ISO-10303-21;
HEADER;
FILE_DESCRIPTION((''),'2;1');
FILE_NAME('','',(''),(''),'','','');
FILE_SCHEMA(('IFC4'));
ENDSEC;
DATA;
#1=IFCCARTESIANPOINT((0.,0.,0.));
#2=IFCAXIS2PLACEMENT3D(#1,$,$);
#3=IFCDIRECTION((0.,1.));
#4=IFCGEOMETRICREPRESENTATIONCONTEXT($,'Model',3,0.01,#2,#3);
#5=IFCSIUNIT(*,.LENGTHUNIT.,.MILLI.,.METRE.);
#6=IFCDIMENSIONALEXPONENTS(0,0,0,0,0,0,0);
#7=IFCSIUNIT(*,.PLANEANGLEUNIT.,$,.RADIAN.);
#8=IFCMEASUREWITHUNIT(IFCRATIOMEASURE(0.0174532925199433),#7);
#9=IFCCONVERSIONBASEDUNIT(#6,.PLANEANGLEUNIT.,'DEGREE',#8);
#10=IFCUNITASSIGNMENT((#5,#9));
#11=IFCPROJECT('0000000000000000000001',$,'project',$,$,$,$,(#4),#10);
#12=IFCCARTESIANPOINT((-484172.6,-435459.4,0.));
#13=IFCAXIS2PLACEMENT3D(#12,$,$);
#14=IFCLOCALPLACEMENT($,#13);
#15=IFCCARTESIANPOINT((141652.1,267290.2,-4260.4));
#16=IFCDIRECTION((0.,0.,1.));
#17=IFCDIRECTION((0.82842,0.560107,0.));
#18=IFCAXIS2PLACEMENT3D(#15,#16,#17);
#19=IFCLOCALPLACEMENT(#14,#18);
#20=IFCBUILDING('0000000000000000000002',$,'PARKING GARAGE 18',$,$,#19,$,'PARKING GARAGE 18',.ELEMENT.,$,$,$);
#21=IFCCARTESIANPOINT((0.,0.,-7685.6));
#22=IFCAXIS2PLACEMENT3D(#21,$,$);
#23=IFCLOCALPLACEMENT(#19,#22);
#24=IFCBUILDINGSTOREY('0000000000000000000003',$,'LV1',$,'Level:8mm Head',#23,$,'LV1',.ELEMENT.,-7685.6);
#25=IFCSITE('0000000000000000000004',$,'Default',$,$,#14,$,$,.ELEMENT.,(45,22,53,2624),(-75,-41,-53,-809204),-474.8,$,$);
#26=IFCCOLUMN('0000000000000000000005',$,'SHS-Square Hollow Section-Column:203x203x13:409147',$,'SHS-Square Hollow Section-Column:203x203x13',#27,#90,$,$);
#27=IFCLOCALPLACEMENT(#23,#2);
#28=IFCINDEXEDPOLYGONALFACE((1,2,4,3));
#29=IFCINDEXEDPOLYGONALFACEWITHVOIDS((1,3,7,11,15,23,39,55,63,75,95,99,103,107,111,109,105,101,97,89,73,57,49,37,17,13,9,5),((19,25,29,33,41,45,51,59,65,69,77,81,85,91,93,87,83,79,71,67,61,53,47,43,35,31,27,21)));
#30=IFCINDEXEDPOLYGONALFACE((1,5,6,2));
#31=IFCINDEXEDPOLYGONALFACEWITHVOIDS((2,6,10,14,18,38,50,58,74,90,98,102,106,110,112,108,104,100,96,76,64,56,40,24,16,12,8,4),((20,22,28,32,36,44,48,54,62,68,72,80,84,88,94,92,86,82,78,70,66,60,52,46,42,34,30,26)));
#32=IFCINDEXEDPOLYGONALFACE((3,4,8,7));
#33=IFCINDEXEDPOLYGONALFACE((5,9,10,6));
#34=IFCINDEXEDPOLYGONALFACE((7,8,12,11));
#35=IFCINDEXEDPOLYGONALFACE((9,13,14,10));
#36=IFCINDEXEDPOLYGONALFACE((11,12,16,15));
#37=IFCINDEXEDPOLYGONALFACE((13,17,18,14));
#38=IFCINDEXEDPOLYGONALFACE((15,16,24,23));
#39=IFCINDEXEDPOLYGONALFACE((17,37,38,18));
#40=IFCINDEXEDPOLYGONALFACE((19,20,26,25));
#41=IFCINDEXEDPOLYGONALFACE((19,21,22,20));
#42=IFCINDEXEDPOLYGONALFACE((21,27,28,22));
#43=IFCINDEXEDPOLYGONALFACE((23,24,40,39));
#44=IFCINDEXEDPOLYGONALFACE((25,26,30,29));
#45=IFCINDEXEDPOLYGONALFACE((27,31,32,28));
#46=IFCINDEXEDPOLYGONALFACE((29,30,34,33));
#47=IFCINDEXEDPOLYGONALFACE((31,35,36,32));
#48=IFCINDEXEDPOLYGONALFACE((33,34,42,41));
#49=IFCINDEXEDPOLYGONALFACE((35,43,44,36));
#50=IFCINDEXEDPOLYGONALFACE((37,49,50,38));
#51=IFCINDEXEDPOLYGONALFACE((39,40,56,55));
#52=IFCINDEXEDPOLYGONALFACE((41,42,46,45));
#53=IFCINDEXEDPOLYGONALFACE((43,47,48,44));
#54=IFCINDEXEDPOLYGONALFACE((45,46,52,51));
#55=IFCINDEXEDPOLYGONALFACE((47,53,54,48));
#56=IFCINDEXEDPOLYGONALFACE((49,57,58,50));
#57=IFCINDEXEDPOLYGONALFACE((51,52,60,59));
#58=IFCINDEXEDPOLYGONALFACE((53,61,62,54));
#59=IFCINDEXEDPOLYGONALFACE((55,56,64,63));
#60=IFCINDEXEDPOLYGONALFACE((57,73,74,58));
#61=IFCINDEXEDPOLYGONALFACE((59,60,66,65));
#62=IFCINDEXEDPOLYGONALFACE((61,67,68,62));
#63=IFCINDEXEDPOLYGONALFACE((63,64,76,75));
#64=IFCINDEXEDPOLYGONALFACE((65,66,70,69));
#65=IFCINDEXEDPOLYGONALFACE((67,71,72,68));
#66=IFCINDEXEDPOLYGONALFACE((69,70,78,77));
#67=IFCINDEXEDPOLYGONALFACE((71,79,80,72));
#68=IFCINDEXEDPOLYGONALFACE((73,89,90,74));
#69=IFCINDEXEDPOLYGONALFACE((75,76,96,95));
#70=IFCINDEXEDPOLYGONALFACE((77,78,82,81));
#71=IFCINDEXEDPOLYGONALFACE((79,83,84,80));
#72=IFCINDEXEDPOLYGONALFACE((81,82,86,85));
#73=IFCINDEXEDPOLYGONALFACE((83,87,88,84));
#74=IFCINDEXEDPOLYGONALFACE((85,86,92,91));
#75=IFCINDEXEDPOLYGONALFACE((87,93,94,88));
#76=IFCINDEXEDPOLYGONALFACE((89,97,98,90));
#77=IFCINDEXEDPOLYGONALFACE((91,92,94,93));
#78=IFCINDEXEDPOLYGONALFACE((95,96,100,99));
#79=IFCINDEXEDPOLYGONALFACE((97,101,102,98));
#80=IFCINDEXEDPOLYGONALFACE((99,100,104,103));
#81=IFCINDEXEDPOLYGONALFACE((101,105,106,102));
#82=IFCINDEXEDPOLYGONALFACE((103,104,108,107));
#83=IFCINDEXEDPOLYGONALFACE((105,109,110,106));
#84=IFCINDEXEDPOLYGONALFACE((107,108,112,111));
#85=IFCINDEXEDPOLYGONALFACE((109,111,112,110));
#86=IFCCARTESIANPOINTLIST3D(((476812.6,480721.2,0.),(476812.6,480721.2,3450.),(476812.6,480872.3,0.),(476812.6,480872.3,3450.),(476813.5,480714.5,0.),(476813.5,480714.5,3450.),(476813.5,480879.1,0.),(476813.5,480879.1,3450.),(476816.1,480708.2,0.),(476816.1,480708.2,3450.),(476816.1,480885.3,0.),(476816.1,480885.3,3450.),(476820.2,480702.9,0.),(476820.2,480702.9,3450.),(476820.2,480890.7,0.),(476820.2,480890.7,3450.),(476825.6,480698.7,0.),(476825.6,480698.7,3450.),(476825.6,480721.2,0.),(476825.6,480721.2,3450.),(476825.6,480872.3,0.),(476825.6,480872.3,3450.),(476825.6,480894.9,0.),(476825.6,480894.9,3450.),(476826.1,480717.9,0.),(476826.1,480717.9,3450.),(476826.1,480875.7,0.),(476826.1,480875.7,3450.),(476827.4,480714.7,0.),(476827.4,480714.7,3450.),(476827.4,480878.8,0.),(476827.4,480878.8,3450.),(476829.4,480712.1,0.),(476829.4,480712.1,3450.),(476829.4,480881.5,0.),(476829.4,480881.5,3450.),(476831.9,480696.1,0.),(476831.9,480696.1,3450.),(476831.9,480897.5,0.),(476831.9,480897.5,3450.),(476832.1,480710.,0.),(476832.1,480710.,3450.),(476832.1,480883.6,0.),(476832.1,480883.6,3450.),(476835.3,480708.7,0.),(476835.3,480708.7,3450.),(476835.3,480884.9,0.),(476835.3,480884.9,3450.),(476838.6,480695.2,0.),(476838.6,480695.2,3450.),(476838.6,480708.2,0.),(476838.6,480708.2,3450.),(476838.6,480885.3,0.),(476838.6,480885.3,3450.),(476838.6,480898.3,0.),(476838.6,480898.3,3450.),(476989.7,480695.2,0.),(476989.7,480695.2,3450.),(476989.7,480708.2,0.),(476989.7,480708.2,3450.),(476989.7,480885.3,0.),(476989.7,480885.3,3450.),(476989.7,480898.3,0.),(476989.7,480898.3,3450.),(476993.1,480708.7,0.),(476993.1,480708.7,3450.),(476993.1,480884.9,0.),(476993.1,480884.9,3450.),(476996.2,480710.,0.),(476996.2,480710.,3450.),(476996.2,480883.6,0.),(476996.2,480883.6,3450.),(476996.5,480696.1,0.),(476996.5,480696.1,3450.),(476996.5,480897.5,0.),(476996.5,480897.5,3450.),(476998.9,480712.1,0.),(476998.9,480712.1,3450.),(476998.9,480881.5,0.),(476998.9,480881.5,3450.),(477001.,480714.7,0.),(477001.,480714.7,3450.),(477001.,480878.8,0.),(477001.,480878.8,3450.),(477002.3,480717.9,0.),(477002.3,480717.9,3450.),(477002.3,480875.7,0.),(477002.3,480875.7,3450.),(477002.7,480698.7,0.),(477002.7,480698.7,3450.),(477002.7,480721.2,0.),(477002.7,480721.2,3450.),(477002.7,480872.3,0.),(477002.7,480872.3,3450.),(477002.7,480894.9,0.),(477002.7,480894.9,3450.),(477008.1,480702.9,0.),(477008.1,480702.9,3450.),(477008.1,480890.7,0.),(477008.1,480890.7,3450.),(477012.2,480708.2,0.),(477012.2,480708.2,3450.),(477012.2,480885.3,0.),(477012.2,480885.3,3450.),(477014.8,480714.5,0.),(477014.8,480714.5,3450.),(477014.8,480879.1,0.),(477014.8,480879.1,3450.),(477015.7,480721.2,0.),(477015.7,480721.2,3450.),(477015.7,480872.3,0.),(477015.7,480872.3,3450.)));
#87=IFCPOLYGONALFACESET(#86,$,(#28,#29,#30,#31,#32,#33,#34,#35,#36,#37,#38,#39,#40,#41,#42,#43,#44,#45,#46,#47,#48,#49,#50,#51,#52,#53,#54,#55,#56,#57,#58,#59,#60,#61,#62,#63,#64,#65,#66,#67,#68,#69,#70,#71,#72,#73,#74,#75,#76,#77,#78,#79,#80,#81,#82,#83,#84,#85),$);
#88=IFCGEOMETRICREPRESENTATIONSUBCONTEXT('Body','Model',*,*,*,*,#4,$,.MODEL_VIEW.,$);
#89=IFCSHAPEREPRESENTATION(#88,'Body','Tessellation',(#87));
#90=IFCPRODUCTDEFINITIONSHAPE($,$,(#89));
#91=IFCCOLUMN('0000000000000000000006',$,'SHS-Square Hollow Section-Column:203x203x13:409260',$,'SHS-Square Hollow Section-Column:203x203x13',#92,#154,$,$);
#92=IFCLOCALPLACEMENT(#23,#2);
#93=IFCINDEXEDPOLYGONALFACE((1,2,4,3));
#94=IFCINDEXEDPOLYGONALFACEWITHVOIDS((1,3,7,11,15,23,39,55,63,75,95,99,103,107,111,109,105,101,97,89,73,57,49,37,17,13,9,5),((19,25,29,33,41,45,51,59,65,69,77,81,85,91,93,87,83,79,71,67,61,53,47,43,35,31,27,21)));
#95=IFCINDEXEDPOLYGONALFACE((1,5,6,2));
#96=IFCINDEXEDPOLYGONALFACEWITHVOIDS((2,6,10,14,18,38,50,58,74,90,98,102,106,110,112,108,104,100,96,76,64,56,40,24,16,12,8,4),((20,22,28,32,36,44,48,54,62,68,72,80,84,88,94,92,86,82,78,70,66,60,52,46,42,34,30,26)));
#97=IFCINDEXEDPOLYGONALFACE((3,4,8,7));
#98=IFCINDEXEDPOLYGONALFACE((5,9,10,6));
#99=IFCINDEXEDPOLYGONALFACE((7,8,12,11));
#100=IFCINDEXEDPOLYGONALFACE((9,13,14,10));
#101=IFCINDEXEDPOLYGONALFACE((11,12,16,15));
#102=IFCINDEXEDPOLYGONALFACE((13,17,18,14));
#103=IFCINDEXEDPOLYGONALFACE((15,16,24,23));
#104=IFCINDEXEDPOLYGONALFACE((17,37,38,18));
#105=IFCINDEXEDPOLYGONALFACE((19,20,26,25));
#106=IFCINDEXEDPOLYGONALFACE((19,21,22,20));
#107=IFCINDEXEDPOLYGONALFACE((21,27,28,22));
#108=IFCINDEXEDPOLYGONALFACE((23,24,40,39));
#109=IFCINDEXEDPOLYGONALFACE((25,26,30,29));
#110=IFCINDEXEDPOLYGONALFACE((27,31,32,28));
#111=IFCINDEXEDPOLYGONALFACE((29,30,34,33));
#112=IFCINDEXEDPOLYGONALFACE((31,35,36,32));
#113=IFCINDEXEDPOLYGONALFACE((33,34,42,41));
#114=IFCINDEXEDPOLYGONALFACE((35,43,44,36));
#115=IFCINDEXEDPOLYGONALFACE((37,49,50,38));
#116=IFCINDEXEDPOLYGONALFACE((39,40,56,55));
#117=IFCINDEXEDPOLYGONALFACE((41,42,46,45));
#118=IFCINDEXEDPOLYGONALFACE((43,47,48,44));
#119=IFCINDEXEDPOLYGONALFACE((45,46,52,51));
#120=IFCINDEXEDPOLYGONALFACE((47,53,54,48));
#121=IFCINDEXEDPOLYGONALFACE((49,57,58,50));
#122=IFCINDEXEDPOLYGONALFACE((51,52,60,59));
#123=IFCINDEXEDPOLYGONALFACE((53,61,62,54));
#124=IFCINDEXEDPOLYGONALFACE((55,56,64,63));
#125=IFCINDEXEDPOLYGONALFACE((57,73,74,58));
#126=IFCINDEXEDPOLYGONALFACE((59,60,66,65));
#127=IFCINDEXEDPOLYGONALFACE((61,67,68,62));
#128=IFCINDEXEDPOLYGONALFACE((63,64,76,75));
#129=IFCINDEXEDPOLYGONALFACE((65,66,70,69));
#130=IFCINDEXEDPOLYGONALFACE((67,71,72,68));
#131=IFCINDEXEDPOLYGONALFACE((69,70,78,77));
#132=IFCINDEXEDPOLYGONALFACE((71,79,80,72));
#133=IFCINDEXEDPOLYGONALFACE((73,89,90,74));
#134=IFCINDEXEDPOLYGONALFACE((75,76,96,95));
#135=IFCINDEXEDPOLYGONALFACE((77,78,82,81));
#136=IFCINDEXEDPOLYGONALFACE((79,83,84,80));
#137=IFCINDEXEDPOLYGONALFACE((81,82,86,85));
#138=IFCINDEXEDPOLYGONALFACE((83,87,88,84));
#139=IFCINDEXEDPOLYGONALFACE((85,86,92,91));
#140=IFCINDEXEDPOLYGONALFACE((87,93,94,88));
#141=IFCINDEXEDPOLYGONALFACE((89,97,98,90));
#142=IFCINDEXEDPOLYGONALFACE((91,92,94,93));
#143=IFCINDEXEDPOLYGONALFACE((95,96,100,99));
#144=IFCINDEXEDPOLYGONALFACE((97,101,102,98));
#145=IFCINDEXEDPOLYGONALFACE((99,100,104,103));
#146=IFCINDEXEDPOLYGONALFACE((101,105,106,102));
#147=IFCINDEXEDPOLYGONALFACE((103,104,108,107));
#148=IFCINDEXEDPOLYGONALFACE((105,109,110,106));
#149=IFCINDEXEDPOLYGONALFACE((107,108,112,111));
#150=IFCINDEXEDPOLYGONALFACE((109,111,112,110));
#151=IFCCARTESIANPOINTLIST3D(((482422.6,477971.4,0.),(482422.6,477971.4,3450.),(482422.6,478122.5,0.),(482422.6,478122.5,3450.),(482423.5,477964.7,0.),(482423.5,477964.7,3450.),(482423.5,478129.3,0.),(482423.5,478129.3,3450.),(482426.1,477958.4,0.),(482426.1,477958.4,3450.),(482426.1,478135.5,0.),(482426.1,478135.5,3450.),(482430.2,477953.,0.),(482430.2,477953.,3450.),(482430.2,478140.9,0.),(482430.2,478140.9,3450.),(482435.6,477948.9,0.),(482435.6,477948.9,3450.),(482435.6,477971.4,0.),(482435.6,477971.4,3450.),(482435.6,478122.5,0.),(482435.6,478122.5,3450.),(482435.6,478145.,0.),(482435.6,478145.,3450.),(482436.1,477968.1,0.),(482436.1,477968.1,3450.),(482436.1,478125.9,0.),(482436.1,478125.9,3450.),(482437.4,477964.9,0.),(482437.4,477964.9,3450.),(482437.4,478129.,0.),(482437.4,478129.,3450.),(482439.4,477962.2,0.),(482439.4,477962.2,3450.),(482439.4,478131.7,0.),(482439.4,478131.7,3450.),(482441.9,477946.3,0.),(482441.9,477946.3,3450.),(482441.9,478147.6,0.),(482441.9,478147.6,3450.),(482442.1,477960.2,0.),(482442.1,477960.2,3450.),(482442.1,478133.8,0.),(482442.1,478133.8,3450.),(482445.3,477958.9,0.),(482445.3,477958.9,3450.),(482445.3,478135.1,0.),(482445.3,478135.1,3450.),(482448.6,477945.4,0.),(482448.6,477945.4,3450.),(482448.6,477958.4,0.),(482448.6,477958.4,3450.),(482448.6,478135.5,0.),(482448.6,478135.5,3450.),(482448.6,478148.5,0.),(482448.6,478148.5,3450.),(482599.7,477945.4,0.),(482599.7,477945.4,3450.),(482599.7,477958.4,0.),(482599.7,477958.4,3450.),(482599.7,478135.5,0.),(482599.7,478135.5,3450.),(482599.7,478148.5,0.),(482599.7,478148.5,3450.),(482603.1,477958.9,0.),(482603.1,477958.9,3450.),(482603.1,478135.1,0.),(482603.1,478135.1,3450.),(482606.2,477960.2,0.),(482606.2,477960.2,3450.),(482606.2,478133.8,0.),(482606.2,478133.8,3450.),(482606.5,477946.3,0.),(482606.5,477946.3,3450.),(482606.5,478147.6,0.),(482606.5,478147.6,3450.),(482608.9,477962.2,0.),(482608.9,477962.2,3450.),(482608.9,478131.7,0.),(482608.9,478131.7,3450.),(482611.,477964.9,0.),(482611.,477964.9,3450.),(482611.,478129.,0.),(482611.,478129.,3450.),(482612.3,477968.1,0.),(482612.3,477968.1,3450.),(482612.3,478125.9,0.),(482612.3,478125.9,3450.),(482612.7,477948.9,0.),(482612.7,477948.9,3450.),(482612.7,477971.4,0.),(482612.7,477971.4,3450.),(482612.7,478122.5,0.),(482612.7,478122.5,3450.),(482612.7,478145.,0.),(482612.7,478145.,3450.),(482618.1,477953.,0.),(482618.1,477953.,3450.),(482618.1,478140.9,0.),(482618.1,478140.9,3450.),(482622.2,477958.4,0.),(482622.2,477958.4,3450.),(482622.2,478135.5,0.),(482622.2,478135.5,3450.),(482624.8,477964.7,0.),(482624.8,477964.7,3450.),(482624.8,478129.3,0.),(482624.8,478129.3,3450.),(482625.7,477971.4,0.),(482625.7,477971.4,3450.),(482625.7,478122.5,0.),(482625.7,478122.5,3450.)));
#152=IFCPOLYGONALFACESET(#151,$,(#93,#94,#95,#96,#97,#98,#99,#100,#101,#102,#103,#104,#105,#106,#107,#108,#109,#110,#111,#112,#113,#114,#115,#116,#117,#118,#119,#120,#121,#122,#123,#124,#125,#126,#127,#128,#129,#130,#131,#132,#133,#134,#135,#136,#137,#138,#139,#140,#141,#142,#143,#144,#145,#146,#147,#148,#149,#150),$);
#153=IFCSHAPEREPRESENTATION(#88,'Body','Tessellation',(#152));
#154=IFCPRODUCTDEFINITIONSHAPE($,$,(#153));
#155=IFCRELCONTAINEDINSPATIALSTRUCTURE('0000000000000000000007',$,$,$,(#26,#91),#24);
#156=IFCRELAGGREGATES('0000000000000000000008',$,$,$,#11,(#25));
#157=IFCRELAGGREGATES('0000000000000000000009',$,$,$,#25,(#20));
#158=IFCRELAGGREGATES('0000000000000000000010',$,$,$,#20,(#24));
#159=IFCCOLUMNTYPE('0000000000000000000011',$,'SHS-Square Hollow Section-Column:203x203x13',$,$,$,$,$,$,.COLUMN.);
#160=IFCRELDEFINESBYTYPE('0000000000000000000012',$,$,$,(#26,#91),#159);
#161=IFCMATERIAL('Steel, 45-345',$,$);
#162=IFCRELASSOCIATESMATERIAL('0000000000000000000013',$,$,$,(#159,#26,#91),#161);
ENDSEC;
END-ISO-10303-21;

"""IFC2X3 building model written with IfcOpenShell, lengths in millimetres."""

from ifc_helpers import new_model, entity, si_unit, converted_unit, direction, frame, frame_2d, origin, place, context, subcontext, project, spatial, polyline, circle_curve, parameter, trimmed, segment, composite_curve, outline, extrude, source, transform, mapped, material, type_object, type_shapes, element, save


model = new_model("IFC2X3")

# Units and contexts
model_context = context("Model", 3, precision=0.01, world=origin(), true_north=direction((0.0, 1.0)))
body_context = subcontext(model_context, "Body", "Model", "MODEL_VIEW")
ifc_project = project(units=[si_unit("LENGTHUNIT", "METRE", prefix="MILLI"), converted_unit("PLANEANGLEUNIT", "DEGREE", entity("IfcRatioMeasure", 0.0174532925199433), si_unit("PLANEANGLEUNIT", "RADIAN"), dimensions=[0, 0, 0, 0, 0, 0, 0])], contexts=[model_context])

# Site, building, storey
site_placement = place(None, frame((-484172.6, -435459.4, 0.0)))
site = spatial("IfcSite", under=ifc_project, at=site_placement, Name="Default", CompositionType="ELEMENT", RefLatitude=(45, 22, 53, 2624), RefLongitude=(-75, -41, -53, -809204), RefElevation=-474.8)
building_placement = place(site_placement, frame((141652.1, 267290.2, -4260.4), z_axis=(0.0, 0.0, 1.0), x_axis=(0.82842, 0.560107, 0.0)))
building = spatial("IfcBuilding", under=site, at=building_placement, Name="PARKING GARAGE 18", LongName="PARKING GARAGE 18", CompositionType="ELEMENT")
storey_placement = place(building_placement, frame((0.0, 0.0, -7685.6)))
storey = spatial("IfcBuildingStorey", under=building, at=storey_placement, Name="LV1", ObjectType="Level:8mm Head", LongName="LV1", CompositionType="ELEMENT", Elevation=-7685.6)

# Columns
ifc_material_1 = material(Name="Steel, 45-345")
column_type_1 = type_object("IfcColumnType", Name="SHS-Square Hollow Section-Column:203x203x13", PredefinedType="COLUMN", material=ifc_material_1)
shared_shape_1 = source(origin(), body_context, "Body", "SweptSolid", [
    extrude(outline(composite_curve([segment(polyline([(-75.6, -101.5), (75.6, -101.5)]), True, "CONTINUOUS"), segment(trimmed(circle_curve(frame_2d((75.6, -75.6), x_axis=(-1.0, 0.0)), 26.0), [parameter(90.0)], [parameter(180.0)], True, "PARAMETER"), True, "CONTINUOUS"), segment(polyline([(101.5, -75.6), (101.5, 75.6)]), True, "CONTINUOUS"), segment(trimmed(circle_curve(frame_2d((75.5, 75.6), x_axis=(-1.0, 0.0)), 26.0), [parameter(180.0)], [parameter(270.0)], True, "PARAMETER"), True, "CONTINUOUS"), segment(polyline([(75.5, 101.6), (-75.5, 101.6)]), True, "CONTINUOUS"), segment(trimmed(circle_curve(frame_2d((-75.5, 75.5), x_axis=(-1.0, 0.0)), 26.0), [parameter(270.0)], [parameter(360.0)], True, "PARAMETER"), True, "CONTINUOUS"), segment(polyline([(-101.5, 75.5), (-101.5, -75.6)]), True, "CONTINUOUS"), segment(trimmed(circle_curve(frame_2d((-75.6, -75.6), x_axis=(-1.0, 0.0)), 26.0), [parameter(360.0)], [parameter(90.0)], True, "PARAMETER"), True, "CONTINUOUS")], self_intersect=False), holes=[composite_curve([segment(trimmed(circle_curve(frame_2d((-75.6, -75.6), x_axis=(-1.0, 0.0)), 13.0), [parameter(0.0)], [parameter(90.0)], True, "PARAMETER"), False, "CONTINUOUS"), segment(polyline([(-88.5, -75.6), (-88.5, 75.6)]), True, "CONTINUOUS"), segment(trimmed(circle_curve(frame_2d((-75.6, 75.6), x_axis=(-1.0, 0.0)), 13.0), [parameter(270.0)], [parameter(0.0)], True, "PARAMETER"), False, "CONTINUOUS"), segment(polyline([(-75.6, 88.6), (75.5, 88.6)]), True, "CONTINUOUS"), segment(trimmed(circle_curve(frame_2d((75.5, 75.5), x_axis=(-1.0, 0.0)), 13.0), [parameter(180.0)], [parameter(270.0)], True, "PARAMETER"), False, "CONTINUOUS"), segment(polyline([(88.6, 75.5), (88.6, -75.5)]), True, "CONTINUOUS"), segment(trimmed(circle_curve(frame_2d((75.6, -75.5), x_axis=(-1.0, 0.0)), 13.0), [parameter(90.0)], [parameter(180.0)], True, "PARAMETER"), False, "CONTINUOUS"), segment(polyline([(75.6, -88.5), (-75.6, -88.5)]), True, "CONTINUOUS")], self_intersect=False)]), frame((0.0, 0.0, -7685.6), z_axis=(0.0, 0.0, 1.0), x_axis=(-1.0, 0.0, 0.0)), (0.0, 0.0, 1.0), 3450.0),
])
type_shapes(column_type_1, [shared_shape_1])
for number, where, name in (
    (1, (476914.2, 480796.8, 7685.6), "SHS-Square Hollow Section-Column:203x203x13:409147"),
    (2, (482524.2, 478047.0, 7685.6), "SHS-Square Hollow Section-Column:203x203x13:409260"),
):
    element("IfcColumn", number, at=place(storey_placement, frame(where)), inside=storey, type_object=column_type_1, material=ifc_material_1, Name=name, ObjectType="SHS-Square Hollow Section-Column:203x203x13", context=body_context, shape_type="MappedRepresentation", body=[
        mapped(shared_shape_1, transform((0.0, 0.0, 0.0), scale=1.0)),
    ])

save(model, "model.ifc")
